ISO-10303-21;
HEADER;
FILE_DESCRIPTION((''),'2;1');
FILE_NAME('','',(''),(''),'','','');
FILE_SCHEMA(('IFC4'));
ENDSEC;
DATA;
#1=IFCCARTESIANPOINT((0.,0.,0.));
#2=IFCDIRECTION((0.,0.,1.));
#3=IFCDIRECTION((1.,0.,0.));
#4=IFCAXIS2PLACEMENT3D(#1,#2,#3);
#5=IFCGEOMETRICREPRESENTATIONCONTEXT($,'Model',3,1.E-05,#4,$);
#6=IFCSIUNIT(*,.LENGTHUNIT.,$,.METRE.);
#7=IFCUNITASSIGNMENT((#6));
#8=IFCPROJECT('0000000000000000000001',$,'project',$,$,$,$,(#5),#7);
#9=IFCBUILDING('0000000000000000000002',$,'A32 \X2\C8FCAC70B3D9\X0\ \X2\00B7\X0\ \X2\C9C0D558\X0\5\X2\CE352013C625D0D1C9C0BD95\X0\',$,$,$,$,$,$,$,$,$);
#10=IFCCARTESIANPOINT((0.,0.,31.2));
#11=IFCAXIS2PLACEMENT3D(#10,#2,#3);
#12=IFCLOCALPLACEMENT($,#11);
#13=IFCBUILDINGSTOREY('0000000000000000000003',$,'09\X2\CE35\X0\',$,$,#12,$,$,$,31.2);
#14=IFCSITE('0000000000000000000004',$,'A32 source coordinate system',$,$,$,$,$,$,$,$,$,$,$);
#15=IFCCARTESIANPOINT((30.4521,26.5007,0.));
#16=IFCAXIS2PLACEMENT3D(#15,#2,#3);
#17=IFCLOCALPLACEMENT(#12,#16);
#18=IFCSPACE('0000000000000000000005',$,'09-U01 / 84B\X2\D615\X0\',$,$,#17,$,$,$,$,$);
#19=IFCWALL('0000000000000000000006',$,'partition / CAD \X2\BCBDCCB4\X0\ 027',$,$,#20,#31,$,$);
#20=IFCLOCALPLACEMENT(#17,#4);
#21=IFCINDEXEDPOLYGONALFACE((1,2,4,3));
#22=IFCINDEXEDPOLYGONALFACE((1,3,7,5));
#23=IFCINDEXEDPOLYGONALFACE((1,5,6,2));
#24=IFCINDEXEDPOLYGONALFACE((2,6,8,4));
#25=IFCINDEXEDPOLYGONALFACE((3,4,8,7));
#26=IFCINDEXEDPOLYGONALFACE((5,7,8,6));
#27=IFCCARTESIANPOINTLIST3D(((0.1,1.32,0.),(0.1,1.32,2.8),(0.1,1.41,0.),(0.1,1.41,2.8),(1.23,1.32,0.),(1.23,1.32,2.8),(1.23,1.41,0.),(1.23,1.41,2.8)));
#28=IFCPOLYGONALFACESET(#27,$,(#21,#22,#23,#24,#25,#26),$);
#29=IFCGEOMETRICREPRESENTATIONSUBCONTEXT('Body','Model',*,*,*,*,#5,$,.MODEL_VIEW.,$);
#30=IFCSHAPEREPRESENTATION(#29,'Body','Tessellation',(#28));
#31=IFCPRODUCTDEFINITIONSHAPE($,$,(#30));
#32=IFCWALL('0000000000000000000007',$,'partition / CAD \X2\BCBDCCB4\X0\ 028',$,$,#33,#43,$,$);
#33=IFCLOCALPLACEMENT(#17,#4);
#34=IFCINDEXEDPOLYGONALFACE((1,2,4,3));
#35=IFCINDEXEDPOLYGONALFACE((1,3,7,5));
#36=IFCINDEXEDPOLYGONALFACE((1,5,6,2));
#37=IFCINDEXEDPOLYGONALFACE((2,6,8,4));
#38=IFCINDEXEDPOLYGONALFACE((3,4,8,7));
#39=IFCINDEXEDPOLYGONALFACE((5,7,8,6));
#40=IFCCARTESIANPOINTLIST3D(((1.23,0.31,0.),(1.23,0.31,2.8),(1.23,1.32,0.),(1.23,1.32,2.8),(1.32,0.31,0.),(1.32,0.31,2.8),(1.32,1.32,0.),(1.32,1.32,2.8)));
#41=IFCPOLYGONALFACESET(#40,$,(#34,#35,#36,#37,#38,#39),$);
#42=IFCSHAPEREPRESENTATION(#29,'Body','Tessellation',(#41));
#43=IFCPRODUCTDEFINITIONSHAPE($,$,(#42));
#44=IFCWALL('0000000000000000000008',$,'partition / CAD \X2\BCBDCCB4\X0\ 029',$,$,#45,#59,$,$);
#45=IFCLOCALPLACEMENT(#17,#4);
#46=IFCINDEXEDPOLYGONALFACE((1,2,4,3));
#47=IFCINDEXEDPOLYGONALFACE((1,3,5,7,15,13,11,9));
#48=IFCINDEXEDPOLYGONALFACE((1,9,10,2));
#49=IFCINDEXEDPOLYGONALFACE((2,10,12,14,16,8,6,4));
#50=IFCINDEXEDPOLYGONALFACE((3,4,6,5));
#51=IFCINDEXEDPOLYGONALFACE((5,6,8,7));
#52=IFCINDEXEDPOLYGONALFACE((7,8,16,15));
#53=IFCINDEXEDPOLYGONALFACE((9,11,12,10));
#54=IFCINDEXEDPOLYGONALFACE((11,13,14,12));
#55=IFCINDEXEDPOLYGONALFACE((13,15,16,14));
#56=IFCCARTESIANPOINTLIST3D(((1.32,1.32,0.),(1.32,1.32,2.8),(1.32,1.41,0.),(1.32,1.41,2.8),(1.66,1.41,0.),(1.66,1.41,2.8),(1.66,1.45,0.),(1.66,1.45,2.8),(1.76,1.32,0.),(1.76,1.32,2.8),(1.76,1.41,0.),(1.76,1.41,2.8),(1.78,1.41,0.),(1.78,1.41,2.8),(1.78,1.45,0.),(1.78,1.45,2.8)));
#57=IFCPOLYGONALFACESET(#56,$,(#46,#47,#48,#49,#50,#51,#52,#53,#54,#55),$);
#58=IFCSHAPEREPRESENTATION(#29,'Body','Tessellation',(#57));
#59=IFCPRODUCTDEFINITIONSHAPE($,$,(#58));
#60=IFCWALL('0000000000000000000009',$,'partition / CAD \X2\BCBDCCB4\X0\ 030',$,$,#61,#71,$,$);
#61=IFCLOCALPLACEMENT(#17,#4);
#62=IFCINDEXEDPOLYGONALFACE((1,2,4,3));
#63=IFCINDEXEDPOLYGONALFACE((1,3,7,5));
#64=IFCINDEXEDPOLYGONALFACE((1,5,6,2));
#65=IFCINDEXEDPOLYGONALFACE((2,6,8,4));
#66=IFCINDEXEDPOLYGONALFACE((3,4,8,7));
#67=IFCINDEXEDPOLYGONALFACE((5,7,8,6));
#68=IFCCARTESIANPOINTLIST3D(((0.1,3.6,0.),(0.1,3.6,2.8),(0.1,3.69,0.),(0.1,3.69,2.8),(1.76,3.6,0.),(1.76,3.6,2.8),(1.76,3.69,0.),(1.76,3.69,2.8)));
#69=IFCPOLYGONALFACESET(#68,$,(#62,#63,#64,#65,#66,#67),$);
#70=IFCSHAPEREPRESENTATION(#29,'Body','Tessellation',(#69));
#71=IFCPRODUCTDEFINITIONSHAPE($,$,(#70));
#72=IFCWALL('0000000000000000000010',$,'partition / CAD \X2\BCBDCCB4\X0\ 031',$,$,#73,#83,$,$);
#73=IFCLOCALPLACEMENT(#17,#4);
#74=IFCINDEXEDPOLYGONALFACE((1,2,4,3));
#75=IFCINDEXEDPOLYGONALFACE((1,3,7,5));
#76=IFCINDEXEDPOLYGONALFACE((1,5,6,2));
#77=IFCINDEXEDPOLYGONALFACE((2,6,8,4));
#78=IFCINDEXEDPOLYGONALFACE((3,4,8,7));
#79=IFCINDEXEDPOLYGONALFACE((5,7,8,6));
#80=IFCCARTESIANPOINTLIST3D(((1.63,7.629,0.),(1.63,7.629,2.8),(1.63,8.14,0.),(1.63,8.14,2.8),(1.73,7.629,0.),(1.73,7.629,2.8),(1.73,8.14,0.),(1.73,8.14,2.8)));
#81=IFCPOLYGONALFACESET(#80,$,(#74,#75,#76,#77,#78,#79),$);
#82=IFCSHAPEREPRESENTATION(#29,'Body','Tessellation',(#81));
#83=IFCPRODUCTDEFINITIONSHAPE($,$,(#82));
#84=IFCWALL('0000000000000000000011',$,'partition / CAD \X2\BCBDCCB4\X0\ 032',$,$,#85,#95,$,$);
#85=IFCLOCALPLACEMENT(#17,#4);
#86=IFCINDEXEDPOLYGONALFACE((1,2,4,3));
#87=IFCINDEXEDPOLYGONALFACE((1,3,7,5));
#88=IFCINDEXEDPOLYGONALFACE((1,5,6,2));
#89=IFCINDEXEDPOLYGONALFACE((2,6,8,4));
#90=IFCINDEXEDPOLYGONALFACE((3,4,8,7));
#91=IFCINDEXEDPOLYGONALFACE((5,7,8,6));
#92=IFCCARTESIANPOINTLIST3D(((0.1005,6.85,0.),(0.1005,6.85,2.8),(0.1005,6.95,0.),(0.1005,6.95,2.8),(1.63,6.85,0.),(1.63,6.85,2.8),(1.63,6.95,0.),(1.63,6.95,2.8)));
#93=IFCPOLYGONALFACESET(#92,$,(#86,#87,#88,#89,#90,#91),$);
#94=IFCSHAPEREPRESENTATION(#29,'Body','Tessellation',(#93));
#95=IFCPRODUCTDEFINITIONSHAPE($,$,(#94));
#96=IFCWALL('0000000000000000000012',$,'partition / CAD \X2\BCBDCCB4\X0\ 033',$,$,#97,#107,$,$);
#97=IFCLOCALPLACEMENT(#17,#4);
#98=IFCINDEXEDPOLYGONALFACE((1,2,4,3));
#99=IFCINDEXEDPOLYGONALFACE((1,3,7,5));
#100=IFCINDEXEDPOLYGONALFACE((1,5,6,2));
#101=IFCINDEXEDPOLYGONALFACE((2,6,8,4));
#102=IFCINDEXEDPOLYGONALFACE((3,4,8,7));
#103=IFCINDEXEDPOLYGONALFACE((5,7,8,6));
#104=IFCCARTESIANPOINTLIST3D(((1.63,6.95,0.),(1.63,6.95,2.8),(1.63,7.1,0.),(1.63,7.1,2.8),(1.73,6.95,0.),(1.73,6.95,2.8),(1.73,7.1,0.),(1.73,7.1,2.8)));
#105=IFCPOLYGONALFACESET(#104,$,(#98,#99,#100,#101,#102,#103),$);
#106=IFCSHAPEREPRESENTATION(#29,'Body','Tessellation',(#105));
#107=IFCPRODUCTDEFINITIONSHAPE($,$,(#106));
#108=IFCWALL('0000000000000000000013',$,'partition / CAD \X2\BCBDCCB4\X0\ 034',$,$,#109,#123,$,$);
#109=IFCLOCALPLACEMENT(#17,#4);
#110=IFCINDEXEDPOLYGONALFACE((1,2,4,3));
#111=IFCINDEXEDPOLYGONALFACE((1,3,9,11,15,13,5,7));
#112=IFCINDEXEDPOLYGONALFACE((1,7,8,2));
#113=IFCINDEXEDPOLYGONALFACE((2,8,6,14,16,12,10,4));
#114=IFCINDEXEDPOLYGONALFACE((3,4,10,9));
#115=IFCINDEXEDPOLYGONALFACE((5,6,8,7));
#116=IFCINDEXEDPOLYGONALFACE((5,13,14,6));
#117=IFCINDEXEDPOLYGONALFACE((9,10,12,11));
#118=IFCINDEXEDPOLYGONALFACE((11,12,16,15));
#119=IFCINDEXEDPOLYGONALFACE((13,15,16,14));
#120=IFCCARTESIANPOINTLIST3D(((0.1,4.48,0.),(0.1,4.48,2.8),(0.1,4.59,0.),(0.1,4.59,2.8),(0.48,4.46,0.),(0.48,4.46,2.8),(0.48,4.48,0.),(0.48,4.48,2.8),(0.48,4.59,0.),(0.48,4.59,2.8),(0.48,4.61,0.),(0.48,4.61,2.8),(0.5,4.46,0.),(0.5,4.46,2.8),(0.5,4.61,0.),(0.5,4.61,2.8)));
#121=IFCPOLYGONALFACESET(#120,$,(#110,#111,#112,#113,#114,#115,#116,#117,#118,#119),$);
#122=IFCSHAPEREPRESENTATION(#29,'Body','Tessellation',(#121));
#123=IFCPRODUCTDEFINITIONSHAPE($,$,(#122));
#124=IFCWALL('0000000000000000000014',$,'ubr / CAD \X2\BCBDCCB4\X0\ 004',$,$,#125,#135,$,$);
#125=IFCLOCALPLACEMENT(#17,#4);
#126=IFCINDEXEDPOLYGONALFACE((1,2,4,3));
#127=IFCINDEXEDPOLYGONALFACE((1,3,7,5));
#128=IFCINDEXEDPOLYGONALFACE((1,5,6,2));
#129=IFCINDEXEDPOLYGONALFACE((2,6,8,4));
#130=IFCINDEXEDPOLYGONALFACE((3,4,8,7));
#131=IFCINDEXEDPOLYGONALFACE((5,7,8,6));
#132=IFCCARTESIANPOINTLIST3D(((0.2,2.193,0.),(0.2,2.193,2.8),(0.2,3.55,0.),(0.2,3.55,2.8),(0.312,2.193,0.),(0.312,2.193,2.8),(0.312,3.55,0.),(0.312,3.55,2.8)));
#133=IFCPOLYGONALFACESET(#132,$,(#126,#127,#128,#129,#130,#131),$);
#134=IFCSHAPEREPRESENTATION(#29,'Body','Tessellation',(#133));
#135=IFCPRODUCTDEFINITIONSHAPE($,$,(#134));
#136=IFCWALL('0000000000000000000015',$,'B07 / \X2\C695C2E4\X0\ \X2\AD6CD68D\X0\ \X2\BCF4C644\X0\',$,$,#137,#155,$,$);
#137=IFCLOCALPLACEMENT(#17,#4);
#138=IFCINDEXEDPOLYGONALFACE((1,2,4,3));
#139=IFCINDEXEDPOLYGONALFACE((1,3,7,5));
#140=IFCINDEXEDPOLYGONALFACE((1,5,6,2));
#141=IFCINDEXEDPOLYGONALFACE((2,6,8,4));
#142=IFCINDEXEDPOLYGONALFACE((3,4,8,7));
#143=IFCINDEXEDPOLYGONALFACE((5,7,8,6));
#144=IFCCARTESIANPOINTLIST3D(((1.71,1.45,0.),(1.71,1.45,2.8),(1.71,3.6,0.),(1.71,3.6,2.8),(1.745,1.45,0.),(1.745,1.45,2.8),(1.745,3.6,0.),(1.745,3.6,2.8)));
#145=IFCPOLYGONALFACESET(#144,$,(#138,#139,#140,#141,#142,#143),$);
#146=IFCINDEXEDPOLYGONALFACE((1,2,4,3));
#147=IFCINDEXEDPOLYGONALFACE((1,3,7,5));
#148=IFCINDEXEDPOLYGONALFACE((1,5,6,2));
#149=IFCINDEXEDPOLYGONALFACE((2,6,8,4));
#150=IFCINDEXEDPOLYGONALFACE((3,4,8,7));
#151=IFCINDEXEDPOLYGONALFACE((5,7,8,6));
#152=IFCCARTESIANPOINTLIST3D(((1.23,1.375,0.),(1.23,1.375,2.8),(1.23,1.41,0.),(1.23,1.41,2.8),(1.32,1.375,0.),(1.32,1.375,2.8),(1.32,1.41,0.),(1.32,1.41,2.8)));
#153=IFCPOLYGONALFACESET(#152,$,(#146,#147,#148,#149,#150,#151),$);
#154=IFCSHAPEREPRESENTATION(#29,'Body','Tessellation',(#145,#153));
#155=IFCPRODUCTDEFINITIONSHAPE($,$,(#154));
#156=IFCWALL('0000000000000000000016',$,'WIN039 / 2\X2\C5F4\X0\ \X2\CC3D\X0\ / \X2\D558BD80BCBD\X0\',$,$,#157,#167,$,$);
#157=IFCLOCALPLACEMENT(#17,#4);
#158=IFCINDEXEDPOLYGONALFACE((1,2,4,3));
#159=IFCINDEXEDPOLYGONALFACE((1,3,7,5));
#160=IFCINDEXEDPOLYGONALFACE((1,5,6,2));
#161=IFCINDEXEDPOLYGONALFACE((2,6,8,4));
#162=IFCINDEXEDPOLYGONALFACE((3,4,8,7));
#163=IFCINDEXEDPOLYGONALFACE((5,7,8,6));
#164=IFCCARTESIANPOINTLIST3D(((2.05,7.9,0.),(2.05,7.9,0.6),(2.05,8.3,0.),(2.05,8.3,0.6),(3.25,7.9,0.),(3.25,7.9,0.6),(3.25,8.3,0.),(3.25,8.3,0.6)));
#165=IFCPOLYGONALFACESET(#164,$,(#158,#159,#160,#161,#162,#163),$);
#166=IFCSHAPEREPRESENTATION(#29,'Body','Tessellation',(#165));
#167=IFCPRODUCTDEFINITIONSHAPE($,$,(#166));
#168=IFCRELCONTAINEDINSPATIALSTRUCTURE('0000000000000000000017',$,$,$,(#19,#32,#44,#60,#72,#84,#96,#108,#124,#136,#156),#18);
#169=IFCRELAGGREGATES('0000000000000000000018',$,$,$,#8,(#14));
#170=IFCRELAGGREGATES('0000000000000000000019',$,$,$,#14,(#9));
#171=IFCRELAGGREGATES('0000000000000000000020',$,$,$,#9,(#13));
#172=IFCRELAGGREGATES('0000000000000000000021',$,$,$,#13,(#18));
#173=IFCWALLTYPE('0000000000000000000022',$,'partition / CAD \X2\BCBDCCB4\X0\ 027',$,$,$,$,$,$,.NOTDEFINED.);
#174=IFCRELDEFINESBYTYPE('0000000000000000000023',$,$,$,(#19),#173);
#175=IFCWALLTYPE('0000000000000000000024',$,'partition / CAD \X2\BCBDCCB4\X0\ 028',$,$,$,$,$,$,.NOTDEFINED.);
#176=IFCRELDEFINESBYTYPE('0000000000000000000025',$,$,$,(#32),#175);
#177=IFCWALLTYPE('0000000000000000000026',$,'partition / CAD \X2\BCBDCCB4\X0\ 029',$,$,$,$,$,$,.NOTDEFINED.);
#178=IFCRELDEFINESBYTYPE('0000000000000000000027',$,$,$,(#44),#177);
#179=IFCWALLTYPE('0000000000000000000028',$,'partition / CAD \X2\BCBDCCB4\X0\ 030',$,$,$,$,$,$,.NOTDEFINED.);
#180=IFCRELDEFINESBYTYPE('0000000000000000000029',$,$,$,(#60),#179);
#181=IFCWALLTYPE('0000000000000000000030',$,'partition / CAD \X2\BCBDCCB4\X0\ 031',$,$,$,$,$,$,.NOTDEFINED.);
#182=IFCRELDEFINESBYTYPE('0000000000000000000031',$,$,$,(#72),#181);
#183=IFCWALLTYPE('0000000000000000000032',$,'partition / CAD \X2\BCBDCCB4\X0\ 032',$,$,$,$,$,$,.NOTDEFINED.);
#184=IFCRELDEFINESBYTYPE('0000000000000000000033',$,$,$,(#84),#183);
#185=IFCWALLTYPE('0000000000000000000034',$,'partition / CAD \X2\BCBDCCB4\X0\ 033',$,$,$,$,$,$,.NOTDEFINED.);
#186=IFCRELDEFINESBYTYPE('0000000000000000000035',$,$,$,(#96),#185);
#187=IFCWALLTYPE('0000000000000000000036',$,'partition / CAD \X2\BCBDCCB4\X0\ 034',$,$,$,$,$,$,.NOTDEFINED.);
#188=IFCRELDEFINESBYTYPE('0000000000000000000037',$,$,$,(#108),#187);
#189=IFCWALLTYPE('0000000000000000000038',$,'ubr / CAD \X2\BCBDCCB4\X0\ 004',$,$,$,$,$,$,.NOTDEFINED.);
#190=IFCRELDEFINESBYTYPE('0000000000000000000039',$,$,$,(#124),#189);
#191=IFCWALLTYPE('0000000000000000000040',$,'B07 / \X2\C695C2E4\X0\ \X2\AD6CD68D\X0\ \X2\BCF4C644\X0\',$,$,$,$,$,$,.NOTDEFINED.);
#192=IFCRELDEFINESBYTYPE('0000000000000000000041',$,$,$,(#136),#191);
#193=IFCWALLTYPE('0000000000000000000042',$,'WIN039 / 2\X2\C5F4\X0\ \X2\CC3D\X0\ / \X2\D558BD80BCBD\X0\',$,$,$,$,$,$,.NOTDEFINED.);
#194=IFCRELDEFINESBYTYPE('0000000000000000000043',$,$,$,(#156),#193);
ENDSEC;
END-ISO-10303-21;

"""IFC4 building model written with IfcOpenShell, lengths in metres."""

from ifc_helpers import new_model, si_unit, frame, origin, origin_with_axes, place, context, subcontext, project, spatial, polyline, outline, extrude, source, transform, mapped, type_object, type_shapes, element, save


model = new_model("IFC4")

# Units and contexts
model_context = context("Model", 3, precision=1e-05, world=origin_with_axes())
body_context = subcontext(model_context, "Body", "Model", "MODEL_VIEW")
ifc_project = project(units=[si_unit("LENGTHUNIT", "METRE")], contexts=[model_context])

# Site, building, storey, space
site = spatial("IfcSite", under=ifc_project, Name="A32 source coordinate system")
building = spatial("IfcBuilding", under=site, Name="A32 주거동 · 지하5층–옥탑지붕")
storey_placement = place(None, frame((0.0, 0.0, 31.2), z_axis=(0.0, 0.0, 1.0), x_axis=(1.0, 0.0, 0.0)))
storey = spatial("IfcBuildingStorey", under=building, at=storey_placement, Name="09층", Elevation=31.2)
space_placement = place(storey_placement, frame((30.4521, 26.5007, 0.0), z_axis=(0.0, 0.0, 1.0), x_axis=(1.0, 0.0, 0.0)))
space = spatial("IfcSpace", under=storey, at=space_placement, Name="09-U01 / 84B형")

# Walls
wall_type_1 = type_object("IfcWallType", Name="partition / CAD 벽체 027", PredefinedType="NOTDEFINED")
shared_shape_1 = source(origin(), body_context, "Body", "SweptSolid", [
    extrude(outline(polyline([(0.1, 1.32), (0.1, 1.41), (1.23, 1.41), (1.23, 1.32), (0.1, 1.32)])), origin(), (0.0, 0.0, 1.0), 2.8),
])
type_shapes(wall_type_1, [shared_shape_1])
wall_1_placement = place(space_placement, origin_with_axes())
element("IfcWall", 1, at=wall_1_placement, inside=space, type_object=wall_type_1, Name="partition / CAD 벽체 027", context=body_context, shape_type="MappedRepresentation", body=[
    mapped(shared_shape_1, transform((0.0, 0.0, 0.0), scale=1.0)),
])
wall_type_2 = type_object("IfcWallType", Name="partition / CAD 벽체 028", PredefinedType="NOTDEFINED")
shared_shape_2 = source(origin(), body_context, "Body", "SweptSolid", [
    extrude(outline(polyline([(1.32, 0.31), (1.23, 0.31), (1.23, 1.32), (1.32, 1.32), (1.32, 0.31)])), origin(), (0.0, 0.0, 1.0), 2.8),
])
type_shapes(wall_type_2, [shared_shape_2])
wall_2_placement = place(space_placement, origin_with_axes())
element("IfcWall", 2, at=wall_2_placement, inside=space, type_object=wall_type_2, Name="partition / CAD 벽체 028", context=body_context, shape_type="MappedRepresentation", body=[
    mapped(shared_shape_2, transform((0.0, 0.0, 0.0), scale=1.0)),
])
wall_type_3 = type_object("IfcWallType", Name="partition / CAD 벽체 029", PredefinedType="NOTDEFINED")
shared_shape_3 = source(origin(), body_context, "Body", "SweptSolid", [
    extrude(outline(polyline([(1.66, 1.41), (1.66, 1.45), (1.78, 1.45), (1.78, 1.41), (1.76, 1.41), (1.76, 1.32), (1.32, 1.32), (1.32, 1.41), (1.66, 1.41)])), origin(), (0.0, 0.0, 1.0), 2.8),
])
type_shapes(wall_type_3, [shared_shape_3])
wall_3_placement = place(space_placement, origin_with_axes())
element("IfcWall", 3, at=wall_3_placement, inside=space, type_object=wall_type_3, Name="partition / CAD 벽체 029", context=body_context, shape_type="MappedRepresentation", body=[
    mapped(shared_shape_3, transform((0.0, 0.0, 0.0), scale=1.0)),
])
wall_type_4 = type_object("IfcWallType", Name="partition / CAD 벽체 030", PredefinedType="NOTDEFINED")
shared_shape_4 = source(origin(), body_context, "Body", "SweptSolid", [
    extrude(outline(polyline([(1.76, 3.69), (1.76, 3.6), (0.1, 3.6), (0.1, 3.69), (1.76, 3.69)])), origin(), (0.0, 0.0, 1.0), 2.8),
])
type_shapes(wall_type_4, [shared_shape_4])
wall_4_placement = place(space_placement, origin_with_axes())
element("IfcWall", 4, at=wall_4_placement, inside=space, type_object=wall_type_4, Name="partition / CAD 벽체 030", context=body_context, shape_type="MappedRepresentation", body=[
    mapped(shared_shape_4, transform((0.0, 0.0, 0.0), scale=1.0)),
])
wall_type_5 = type_object("IfcWallType", Name="partition / CAD 벽체 031", PredefinedType="NOTDEFINED")
shared_shape_5 = source(origin(), body_context, "Body", "SweptSolid", [
    extrude(outline(polyline([(1.63, 8.14), (1.73, 8.14), (1.73, 7.629), (1.63, 7.629), (1.63, 8.14)])), origin(), (0.0, 0.0, 1.0), 2.8),
])
type_shapes(wall_type_5, [shared_shape_5])
wall_5_placement = place(space_placement, origin_with_axes())
element("IfcWall", 5, at=wall_5_placement, inside=space, type_object=wall_type_5, Name="partition / CAD 벽체 031", context=body_context, shape_type="MappedRepresentation", body=[
    mapped(shared_shape_5, transform((0.0, 0.0, 0.0), scale=1.0)),
])
wall_type_6 = type_object("IfcWallType", Name="partition / CAD 벽체 032", PredefinedType="NOTDEFINED")
shared_shape_6 = source(origin(), body_context, "Body", "SweptSolid", [
    extrude(outline(polyline([(0.1005, 6.95), (1.63, 6.95), (1.63, 6.85), (0.1005, 6.85), (0.1005, 6.95)])), origin(), (0.0, 0.0, 1.0), 2.8),
])
type_shapes(wall_type_6, [shared_shape_6])
wall_6_placement = place(space_placement, origin_with_axes())
element("IfcWall", 6, at=wall_6_placement, inside=space, type_object=wall_type_6, Name="partition / CAD 벽체 032", context=body_context, shape_type="MappedRepresentation", body=[
    mapped(shared_shape_6, transform((0.0, 0.0, 0.0), scale=1.0)),
])
wall_type_7 = type_object("IfcWallType", Name="partition / CAD 벽체 033", PredefinedType="NOTDEFINED")
shared_shape_7 = source(origin(), body_context, "Body", "SweptSolid", [
    extrude(outline(polyline([(1.63, 7.1), (1.73, 7.1), (1.73, 6.95), (1.63, 6.95), (1.63, 7.1)])), origin(), (0.0, 0.0, 1.0), 2.8),
])
type_shapes(wall_type_7, [shared_shape_7])
wall_7_placement = place(space_placement, origin_with_axes())
element("IfcWall", 7, at=wall_7_placement, inside=space, type_object=wall_type_7, Name="partition / CAD 벽체 033", context=body_context, shape_type="MappedRepresentation", body=[
    mapped(shared_shape_7, transform((0.0, 0.0, 0.0), scale=1.0)),
])
wall_type_8 = type_object("IfcWallType", Name="partition / CAD 벽체 034", PredefinedType="NOTDEFINED")
shared_shape_8 = source(origin(), body_context, "Body", "SweptSolid", [
    extrude(outline(polyline([(0.48, 4.61), (0.5, 4.61), (0.5, 4.46), (0.48, 4.46), (0.48, 4.48), (0.1, 4.48), (0.1, 4.59), (0.48, 4.59), (0.48, 4.61)])), origin(), (0.0, 0.0, 1.0), 2.8),
])
type_shapes(wall_type_8, [shared_shape_8])
wall_8_placement = place(space_placement, origin_with_axes())
element("IfcWall", 8, at=wall_8_placement, inside=space, type_object=wall_type_8, Name="partition / CAD 벽체 034", context=body_context, shape_type="MappedRepresentation", body=[
    mapped(shared_shape_8, transform((0.0, 0.0, 0.0), scale=1.0)),
])
wall_type_9 = type_object("IfcWallType", Name="ubr / CAD 벽체 004", PredefinedType="NOTDEFINED")
shared_shape_9 = source(origin(), body_context, "Body", "SweptSolid", [
    extrude(outline(polyline([(0.312, 2.193), (0.2, 2.193), (0.2, 3.55), (0.312, 3.55), (0.312, 2.193)])), origin(), (0.0, 0.0, 1.0), 2.8),
])
type_shapes(wall_type_9, [shared_shape_9])
wall_9_placement = place(space_placement, origin_with_axes())
element("IfcWall", 9, at=wall_9_placement, inside=space, type_object=wall_type_9, Name="ubr / CAD 벽체 004", context=body_context, shape_type="MappedRepresentation", body=[
    mapped(shared_shape_9, transform((0.0, 0.0, 0.0), scale=1.0)),
])
wall_type_10 = type_object("IfcWallType", Name="B07 / 욕실 구획 보완", PredefinedType="NOTDEFINED")
shared_shape_10 = source(origin(), body_context, "Body", "SweptSolid", [
    extrude(outline(polyline([(1.71, 1.45), (1.71, 3.6), (1.745, 3.6), (1.745, 1.45), (1.71, 1.45)])), origin(), (0.0, 0.0, 1.0), 2.8),
    extrude(outline(polyline([(1.32, 1.41), (1.32, 1.375), (1.23, 1.375), (1.23, 1.41), (1.32, 1.41)])), origin(), (0.0, 0.0, 1.0), 2.8),
])
type_shapes(wall_type_10, [shared_shape_10])
wall_10_placement = place(space_placement, origin_with_axes())
element("IfcWall", 10, at=wall_10_placement, inside=space, type_object=wall_type_10, Name="B07 / 욕실 구획 보완", context=body_context, shape_type="MappedRepresentation", body=[
    mapped(shared_shape_10, transform((0.0, 0.0, 0.0), scale=1.0)),
])
wall_type_11 = type_object("IfcWallType", Name="WIN039 / 2열 창 / 하부벽", PredefinedType="NOTDEFINED")
shared_shape_11 = source(origin(), body_context, "Body", "SweptSolid", [
    extrude(outline(polyline([(2.05, 8.3), (3.25, 8.3), (3.25, 7.9), (2.05, 7.9), (2.05, 8.3)])), origin(), (0.0, 0.0, 1.0), 0.6),
])
type_shapes(wall_type_11, [shared_shape_11])
wall_11_placement = place(space_placement, origin_with_axes())
element("IfcWall", 11, at=wall_11_placement, inside=space, type_object=wall_type_11, Name="WIN039 / 2열 창 / 하부벽", context=body_context, shape_type="MappedRepresentation", body=[
    mapped(shared_shape_11, transform((0.0, 0.0, 0.0), scale=1.0)),
])

save(model, "model.ifc")
